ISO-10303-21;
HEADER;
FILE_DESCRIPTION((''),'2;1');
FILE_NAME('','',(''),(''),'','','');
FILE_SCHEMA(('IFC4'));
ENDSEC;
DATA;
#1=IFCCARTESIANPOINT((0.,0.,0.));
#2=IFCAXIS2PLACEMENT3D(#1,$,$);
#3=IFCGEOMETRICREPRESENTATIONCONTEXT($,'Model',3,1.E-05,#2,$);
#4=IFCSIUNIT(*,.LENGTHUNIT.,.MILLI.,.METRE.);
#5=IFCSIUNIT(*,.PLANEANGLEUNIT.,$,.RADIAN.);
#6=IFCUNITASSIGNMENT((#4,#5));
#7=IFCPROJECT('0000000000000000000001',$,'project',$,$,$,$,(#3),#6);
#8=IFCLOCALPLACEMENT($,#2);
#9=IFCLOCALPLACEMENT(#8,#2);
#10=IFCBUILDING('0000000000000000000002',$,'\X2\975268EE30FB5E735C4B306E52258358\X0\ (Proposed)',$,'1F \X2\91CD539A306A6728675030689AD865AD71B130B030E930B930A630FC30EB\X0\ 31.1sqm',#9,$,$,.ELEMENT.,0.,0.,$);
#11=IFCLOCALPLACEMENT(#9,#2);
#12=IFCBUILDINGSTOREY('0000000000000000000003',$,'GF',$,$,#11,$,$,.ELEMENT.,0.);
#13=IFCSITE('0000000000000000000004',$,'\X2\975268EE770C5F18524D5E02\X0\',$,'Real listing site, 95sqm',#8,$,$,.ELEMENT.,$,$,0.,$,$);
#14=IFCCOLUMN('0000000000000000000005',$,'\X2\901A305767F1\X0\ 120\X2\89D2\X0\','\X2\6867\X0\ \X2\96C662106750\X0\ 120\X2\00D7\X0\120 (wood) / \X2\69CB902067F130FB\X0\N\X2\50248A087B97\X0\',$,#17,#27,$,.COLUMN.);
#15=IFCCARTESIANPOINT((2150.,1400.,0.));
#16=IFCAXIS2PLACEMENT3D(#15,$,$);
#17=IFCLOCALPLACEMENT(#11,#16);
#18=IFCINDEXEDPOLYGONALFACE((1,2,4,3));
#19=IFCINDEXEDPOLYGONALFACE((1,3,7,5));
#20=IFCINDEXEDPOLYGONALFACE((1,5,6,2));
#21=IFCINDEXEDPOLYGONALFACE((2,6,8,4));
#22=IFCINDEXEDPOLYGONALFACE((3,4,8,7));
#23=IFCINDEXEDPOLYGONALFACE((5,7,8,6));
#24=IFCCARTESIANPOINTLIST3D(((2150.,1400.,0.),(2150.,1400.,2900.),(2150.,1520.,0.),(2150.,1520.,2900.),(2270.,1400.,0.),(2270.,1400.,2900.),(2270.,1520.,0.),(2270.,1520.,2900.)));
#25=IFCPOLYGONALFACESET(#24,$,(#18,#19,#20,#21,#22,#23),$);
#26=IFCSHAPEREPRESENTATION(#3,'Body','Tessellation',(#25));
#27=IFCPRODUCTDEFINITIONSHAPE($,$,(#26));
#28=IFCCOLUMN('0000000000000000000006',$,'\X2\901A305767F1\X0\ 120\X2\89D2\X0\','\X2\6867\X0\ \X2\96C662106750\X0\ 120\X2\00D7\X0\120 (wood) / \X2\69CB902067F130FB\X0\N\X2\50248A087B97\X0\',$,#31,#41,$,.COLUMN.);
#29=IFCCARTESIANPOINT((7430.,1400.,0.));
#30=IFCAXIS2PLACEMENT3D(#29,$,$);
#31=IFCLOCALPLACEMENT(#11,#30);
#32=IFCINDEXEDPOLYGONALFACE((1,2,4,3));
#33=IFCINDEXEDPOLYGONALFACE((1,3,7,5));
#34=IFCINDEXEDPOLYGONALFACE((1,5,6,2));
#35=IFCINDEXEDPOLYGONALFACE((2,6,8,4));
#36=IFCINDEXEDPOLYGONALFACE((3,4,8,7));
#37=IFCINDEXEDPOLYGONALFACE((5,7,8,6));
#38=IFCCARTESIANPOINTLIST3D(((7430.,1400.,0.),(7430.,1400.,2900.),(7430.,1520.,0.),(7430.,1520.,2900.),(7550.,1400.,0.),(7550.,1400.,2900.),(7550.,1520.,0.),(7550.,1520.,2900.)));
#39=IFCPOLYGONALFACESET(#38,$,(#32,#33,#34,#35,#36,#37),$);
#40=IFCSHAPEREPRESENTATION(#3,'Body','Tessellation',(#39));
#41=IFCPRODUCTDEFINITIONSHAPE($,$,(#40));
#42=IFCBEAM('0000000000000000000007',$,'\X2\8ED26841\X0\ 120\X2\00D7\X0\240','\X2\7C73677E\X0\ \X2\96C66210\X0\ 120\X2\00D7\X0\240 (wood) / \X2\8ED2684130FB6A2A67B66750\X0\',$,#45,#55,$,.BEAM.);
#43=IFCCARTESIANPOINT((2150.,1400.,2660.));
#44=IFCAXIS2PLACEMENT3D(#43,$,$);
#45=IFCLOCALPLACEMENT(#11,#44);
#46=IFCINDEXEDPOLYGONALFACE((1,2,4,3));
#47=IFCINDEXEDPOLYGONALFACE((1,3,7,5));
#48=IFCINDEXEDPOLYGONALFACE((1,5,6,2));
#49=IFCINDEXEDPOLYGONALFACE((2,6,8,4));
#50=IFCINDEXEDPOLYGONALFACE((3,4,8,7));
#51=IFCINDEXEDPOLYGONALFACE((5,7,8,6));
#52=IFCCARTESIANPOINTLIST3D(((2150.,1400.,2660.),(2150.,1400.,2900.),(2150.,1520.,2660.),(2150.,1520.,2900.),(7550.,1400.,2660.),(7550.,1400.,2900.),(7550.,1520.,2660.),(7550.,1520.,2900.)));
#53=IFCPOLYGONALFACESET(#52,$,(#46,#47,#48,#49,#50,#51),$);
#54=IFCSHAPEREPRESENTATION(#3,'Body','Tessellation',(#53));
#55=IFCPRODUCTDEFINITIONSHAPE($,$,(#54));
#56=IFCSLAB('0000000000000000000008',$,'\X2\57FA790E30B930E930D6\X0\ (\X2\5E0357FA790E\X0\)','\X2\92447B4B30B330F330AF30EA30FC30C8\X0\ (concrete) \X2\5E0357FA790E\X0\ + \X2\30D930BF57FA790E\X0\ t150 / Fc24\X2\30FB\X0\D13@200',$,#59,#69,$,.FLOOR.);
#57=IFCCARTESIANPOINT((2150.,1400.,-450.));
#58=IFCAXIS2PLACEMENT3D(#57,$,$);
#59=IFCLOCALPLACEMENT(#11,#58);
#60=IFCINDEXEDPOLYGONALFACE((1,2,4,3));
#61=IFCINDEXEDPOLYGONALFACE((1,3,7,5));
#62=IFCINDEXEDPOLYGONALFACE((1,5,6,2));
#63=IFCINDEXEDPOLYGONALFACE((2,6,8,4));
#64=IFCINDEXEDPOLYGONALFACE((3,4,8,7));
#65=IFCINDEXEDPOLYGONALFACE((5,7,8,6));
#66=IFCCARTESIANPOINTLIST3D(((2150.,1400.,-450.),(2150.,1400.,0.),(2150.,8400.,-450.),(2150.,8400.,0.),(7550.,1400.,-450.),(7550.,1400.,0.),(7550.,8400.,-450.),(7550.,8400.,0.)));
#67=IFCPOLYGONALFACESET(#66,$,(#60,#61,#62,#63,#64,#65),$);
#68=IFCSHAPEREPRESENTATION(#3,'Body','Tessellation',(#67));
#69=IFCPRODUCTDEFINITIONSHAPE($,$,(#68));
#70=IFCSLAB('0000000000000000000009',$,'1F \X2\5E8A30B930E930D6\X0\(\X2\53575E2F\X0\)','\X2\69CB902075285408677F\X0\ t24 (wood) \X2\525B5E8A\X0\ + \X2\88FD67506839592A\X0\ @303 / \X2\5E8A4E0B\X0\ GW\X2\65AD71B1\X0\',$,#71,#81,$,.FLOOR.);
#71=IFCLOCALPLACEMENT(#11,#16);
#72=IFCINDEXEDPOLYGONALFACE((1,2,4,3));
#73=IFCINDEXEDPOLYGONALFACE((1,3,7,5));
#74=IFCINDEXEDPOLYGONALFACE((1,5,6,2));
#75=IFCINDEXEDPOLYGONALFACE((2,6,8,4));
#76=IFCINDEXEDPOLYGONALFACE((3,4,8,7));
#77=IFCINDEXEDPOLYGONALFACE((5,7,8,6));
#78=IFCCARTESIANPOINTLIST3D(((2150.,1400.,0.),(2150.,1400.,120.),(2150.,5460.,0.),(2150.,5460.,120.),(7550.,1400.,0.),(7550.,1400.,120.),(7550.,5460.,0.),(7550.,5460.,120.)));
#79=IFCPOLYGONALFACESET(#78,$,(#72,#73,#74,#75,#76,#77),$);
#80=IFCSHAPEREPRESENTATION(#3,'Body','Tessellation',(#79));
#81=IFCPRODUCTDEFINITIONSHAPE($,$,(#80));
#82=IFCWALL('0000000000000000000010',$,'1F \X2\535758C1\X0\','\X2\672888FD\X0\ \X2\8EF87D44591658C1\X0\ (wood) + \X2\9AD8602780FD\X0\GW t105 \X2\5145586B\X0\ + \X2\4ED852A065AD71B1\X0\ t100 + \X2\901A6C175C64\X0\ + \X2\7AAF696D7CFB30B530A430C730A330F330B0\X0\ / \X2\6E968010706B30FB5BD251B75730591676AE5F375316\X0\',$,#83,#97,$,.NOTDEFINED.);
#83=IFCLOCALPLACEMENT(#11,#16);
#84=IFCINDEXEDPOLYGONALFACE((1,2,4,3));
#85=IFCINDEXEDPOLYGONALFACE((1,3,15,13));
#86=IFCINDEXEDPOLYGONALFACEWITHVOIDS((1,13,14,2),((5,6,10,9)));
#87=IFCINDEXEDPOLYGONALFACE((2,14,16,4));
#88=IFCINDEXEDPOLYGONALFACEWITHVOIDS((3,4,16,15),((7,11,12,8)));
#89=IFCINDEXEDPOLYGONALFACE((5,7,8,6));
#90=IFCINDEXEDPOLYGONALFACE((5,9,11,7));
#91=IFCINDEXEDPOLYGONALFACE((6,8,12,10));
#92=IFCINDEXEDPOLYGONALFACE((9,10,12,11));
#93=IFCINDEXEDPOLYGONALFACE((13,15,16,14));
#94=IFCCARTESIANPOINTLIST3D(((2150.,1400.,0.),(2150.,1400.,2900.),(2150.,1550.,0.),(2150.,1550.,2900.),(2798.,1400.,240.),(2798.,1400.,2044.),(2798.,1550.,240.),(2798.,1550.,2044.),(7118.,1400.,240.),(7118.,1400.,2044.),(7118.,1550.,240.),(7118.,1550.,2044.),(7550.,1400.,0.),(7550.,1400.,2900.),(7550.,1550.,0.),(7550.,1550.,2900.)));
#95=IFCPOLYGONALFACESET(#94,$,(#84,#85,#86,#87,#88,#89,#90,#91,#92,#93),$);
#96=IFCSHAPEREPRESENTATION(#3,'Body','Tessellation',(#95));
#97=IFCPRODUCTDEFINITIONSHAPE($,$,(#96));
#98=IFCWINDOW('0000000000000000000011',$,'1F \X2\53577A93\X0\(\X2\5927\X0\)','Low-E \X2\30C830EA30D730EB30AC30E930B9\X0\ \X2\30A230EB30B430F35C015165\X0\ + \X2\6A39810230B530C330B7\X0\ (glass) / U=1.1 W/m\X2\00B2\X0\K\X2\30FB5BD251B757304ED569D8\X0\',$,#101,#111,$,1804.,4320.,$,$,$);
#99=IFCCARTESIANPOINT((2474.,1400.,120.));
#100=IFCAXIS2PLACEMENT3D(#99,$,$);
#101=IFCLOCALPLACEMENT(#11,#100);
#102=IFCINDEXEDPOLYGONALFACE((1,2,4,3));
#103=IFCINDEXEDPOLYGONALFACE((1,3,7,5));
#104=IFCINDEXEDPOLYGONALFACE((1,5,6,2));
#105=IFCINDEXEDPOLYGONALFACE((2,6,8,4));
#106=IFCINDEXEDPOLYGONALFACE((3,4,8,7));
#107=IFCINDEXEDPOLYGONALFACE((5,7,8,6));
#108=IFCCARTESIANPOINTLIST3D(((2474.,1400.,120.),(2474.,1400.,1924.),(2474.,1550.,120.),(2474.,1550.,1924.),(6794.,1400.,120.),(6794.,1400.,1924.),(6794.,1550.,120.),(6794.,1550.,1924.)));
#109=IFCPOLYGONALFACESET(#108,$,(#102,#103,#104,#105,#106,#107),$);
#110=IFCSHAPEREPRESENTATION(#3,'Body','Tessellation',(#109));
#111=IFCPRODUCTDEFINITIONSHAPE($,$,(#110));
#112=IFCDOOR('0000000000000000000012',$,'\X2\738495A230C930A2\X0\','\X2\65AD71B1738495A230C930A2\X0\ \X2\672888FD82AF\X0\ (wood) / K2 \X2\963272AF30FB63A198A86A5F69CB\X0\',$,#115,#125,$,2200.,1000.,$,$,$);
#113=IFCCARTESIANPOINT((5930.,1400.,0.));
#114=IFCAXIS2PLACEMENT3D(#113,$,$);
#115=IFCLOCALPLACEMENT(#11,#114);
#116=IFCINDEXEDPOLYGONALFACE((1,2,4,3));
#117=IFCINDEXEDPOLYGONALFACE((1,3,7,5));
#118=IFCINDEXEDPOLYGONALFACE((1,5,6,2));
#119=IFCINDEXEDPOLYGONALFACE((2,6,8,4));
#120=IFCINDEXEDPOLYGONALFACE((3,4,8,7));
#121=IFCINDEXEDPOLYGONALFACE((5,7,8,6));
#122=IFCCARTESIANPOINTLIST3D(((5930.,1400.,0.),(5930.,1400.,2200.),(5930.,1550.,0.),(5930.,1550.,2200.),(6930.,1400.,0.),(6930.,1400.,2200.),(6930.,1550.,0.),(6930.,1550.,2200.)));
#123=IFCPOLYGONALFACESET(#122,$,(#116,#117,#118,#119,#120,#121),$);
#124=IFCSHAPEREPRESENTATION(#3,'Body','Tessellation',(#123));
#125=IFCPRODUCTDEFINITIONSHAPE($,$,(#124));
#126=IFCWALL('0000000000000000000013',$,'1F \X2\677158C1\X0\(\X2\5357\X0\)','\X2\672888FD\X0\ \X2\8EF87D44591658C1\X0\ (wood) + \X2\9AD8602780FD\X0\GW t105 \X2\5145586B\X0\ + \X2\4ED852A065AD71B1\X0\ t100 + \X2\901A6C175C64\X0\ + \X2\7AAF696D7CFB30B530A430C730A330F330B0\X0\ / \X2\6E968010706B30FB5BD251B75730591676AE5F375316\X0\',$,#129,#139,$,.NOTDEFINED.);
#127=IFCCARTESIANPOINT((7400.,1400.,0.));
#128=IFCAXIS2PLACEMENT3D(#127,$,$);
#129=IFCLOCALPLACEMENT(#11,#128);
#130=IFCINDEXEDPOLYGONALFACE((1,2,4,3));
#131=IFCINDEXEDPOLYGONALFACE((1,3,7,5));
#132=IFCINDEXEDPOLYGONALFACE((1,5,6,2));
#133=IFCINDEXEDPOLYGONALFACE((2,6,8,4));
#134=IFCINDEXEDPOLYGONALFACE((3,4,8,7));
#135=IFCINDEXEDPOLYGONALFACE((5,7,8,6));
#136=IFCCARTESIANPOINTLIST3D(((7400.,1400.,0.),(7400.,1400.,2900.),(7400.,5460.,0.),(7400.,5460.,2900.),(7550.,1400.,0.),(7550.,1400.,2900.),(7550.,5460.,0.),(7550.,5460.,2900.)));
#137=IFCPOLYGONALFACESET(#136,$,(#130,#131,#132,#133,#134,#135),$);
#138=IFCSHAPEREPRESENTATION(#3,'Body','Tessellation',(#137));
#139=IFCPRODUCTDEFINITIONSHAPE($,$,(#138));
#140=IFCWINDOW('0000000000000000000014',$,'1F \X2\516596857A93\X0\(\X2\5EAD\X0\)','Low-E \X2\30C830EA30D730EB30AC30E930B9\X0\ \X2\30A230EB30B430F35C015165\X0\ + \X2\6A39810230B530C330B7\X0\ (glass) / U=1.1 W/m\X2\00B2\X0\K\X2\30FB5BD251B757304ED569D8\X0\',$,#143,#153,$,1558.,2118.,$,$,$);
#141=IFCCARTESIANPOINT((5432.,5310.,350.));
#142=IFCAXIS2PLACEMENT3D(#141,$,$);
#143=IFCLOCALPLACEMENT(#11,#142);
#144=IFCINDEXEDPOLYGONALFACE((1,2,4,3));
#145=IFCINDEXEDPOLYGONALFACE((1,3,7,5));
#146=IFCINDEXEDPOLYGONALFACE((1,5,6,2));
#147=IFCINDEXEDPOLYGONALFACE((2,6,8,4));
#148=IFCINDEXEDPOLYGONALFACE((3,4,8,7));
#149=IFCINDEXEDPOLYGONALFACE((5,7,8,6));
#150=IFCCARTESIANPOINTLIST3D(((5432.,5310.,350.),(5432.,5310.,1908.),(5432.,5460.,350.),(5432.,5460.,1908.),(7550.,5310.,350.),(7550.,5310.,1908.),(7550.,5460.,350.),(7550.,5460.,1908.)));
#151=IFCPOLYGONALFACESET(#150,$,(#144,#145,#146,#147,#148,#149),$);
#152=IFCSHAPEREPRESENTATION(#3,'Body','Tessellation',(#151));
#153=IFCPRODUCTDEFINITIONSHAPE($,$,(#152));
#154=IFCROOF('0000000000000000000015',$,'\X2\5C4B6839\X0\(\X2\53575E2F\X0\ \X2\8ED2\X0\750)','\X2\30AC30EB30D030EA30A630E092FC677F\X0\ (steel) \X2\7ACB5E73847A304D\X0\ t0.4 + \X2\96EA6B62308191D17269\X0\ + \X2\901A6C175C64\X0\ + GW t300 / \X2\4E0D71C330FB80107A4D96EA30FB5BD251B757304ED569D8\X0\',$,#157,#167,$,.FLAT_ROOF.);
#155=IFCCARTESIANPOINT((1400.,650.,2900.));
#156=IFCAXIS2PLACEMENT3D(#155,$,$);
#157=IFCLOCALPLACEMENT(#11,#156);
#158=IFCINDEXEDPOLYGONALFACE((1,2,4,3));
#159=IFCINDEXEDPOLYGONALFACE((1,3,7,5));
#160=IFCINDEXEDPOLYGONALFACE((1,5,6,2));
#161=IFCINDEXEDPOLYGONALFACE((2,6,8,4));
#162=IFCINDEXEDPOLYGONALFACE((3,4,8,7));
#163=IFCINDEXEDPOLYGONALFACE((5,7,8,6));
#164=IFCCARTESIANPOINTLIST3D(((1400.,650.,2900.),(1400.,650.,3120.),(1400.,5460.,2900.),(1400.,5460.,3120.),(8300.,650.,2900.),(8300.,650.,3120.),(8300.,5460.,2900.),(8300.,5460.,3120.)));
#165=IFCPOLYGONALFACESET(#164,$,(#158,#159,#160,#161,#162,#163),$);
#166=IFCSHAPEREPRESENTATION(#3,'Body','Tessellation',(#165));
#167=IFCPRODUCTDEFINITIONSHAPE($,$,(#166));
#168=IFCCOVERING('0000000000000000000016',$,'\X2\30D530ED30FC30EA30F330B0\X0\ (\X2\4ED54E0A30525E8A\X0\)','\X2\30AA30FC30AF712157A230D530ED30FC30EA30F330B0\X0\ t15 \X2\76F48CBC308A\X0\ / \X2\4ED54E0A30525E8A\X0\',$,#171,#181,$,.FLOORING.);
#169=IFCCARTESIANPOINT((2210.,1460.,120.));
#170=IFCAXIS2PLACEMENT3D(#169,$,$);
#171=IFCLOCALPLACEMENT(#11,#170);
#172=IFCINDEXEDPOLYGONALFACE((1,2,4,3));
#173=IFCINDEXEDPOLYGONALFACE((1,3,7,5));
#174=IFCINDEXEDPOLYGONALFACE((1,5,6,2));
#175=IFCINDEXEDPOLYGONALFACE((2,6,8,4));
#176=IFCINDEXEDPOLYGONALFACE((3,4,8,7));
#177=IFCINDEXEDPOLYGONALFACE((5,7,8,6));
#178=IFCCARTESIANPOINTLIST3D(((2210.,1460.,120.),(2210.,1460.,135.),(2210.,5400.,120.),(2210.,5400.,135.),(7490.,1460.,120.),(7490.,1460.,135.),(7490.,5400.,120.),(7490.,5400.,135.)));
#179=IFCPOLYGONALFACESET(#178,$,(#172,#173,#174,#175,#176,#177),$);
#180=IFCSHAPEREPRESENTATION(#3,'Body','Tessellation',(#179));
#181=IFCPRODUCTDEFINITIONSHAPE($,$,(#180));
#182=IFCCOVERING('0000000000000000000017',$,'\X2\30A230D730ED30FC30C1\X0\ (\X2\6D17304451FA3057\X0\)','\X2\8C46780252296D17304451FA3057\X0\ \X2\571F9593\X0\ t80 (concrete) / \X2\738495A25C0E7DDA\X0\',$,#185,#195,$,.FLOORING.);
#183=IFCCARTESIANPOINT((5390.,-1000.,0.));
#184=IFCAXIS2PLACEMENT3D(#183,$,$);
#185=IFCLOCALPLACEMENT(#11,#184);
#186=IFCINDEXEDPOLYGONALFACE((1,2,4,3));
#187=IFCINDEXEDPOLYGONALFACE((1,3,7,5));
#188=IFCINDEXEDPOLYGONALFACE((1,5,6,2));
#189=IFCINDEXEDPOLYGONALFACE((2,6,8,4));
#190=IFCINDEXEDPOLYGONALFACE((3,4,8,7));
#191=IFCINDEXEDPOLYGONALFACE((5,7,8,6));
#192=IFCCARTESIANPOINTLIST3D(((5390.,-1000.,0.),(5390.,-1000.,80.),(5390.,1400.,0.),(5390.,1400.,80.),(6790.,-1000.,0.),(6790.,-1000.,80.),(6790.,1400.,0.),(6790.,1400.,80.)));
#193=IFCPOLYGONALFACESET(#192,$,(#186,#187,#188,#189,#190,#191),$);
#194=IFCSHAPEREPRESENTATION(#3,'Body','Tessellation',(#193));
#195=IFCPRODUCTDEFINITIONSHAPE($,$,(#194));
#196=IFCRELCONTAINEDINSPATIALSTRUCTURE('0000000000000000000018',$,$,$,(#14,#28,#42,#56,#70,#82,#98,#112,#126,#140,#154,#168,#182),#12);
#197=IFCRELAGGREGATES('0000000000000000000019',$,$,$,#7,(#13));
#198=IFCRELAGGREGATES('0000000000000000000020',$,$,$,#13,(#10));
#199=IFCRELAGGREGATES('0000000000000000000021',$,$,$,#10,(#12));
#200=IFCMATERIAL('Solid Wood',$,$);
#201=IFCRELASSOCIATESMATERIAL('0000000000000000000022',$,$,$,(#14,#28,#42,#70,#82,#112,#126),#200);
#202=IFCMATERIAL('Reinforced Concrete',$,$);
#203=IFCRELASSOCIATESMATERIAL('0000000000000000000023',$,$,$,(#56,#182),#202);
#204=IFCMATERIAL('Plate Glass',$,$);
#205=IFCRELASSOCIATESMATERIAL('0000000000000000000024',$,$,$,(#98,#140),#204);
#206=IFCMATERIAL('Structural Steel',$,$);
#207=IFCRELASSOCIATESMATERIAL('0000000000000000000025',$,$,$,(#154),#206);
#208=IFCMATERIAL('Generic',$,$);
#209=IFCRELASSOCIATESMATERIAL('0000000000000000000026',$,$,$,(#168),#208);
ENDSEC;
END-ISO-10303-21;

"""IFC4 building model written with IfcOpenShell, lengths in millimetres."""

from ifc_helpers import new_model, si_unit, frame, frame_2d, origin, place, context, project, spatial, rectangle, extrude, material, element, fill, save


model = new_model("IFC4")

# Units and contexts
model_context = context("Model", 3, precision=1e-05, world=origin())
ifc_project = project(units=[si_unit("LENGTHUNIT", "METRE", prefix="MILLI"), si_unit("PLANEANGLEUNIT", "RADIAN")], contexts=[model_context])

# Site, building, storey
site_placement = place(None, origin())
site = spatial("IfcSite", under=ifc_project, at=site_placement, Name="青森県弘前市", ObjectType="Real listing site, 95sqm", CompositionType="ELEMENT", RefElevation=0.0)
building_placement = place(site_placement, origin())
building = spatial("IfcBuilding", under=site, at=building_placement, Name="青森・平屋の別荘 (Proposed)", ObjectType="1F 重厚な木材と高断熱グラスウール 31.1sqm", CompositionType="ELEMENT", ElevationOfRefHeight=0.0, ElevationOfTerrain=0.0)
storey_placement = place(building_placement, origin())
storey = spatial("IfcBuildingStorey", under=building, at=storey_placement, Name="GF", CompositionType="ELEMENT", Elevation=0.0)

# Columns
ifc_material_1 = material(Name="Solid Wood")
column_1_placement = place(storey_placement, frame((2150.0, 1400.0, 0.0)))
element("IfcColumn", 1, at=column_1_placement, inside=storey, material=ifc_material_1, Name="通し柱 120角", Description="桧 集成材 120×120 (wood) / 構造柱・N値計算", PredefinedType="COLUMN", context=model_context, shape_type="SweptSolid", body=[
    extrude(rectangle(XDim=120.0, YDim=120.0, at=frame_2d((60.0, 60.0))), frame((2150.0, 1400.0, 0.0)), (0.0, 0.0, 1.0), 2900.0),
])
column_2_placement = place(storey_placement, frame((7430.0, 1400.0, 0.0)))
element("IfcColumn", 2, at=column_2_placement, inside=storey, material=ifc_material_1, Name="通し柱 120角", Description="桧 集成材 120×120 (wood) / 構造柱・N値計算", PredefinedType="COLUMN", context=model_context, shape_type="SweptSolid", body=[
    extrude(rectangle(XDim=120.0, YDim=120.0, at=frame_2d((60.0, 60.0))), frame((7430.0, 1400.0, 0.0)), (0.0, 0.0, 1.0), 2900.0),
])

# Beam
beam_1_placement = place(storey_placement, frame((2150.0, 1400.0, 2660.0)))
element("IfcBeam", 3, at=beam_1_placement, inside=storey, material=ifc_material_1, Name="軒桁 120×240", Description="米松 集成 120×240 (wood) / 軒桁・横架材", PredefinedType="BEAM", context=model_context, shape_type="SweptSolid", body=[
    extrude(rectangle(XDim=5400.0, YDim=120.0, at=frame_2d((2700.0, 60.0))), frame((2150.0, 1400.0, 2660.0)), (0.0, 0.0, 1.0), 240.0),
])

# Slabs
ifc_material_2 = material(Name="Reinforced Concrete")
slab_1_placement = place(storey_placement, frame((2150.0, 1400.0, -450.0)))
element("IfcSlab", 4, at=slab_1_placement, inside=storey, material=ifc_material_2, Name="基礎スラブ (布基礎)", Description="鉄筋コンクリート (concrete) 布基礎 + ベタ基礎 t150 / Fc24・D13@200", PredefinedType="FLOOR", context=model_context, shape_type="SweptSolid", body=[
    extrude(rectangle(XDim=5400.0, YDim=7000.0, at=frame_2d((2700.0, 3500.0))), frame((2150.0, 1400.0, -450.0)), (0.0, 0.0, 1.0), 450.0),
])
slab_2_placement = place(storey_placement, frame((2150.0, 1400.0, 0.0)))
element("IfcSlab", 5, at=slab_2_placement, inside=storey, material=ifc_material_1, Name="1F 床スラブ(南帯)", Description="構造用合板 t24 (wood) 剛床 + 製材根太 @303 / 床下 GW断熱", PredefinedType="FLOOR", context=model_context, shape_type="SweptSolid", body=[
    extrude(rectangle(XDim=5400.0, YDim=4060.0, at=frame_2d((2700.0, 2030.0))), frame((2150.0, 1400.0, 0.0)), (0.0, 0.0, 1.0), 120.0),
])

# Wall, openings, window, door
wall_1_placement = place(storey_placement, frame((2150.0, 1400.0, 0.0)))
wall_1 = element("IfcWall", 6, at=wall_1_placement, inside=storey, material=ifc_material_1, Name="1F 南壁", Description="木製 軸組外壁 (wood) + 高性能GW t105 充填 + 付加断熱 t100 + 通気層 + 窯業系サイディング / 準耐火・寒冷地外皮強化", PredefinedType="NOTDEFINED", context=model_context, shape_type="SweptSolid", body=[
    extrude(rectangle(XDim=5400.0, YDim=150.0, at=frame_2d((2700.0, 75.0))), frame((2150.0, 1400.0, 0.0)), (0.0, 0.0, 1.0), 2900.0),
])
opening_1_placement = place(storey_placement, frame((2474.0, 1400.0, 120.0)))
opening_1 = element("IfcOpeningElement", 7, at=opening_1_placement, cuts=wall_1, PredefinedType="NOTDEFINED", context=model_context, shape_type="SweptSolid", body=[
    extrude(rectangle(XDim=4320.0, YDim=150.0, at=frame_2d((2160.0, 75.0))), frame((2474.0, 1400.0, 120.0)), (0.0, 0.0, 1.0), 1804.0),
])
opening_2_placement = place(storey_placement, frame((5930.0, 1400.0, 0.0)))
opening_2 = element("IfcOpeningElement", 8, at=opening_2_placement, cuts=wall_1, PredefinedType="NOTDEFINED", context=model_context, shape_type="SweptSolid", body=[
    extrude(rectangle(XDim=1000.0, YDim=150.0, at=frame_2d((500.0, 75.0))), frame((5930.0, 1400.0, 0.0)), (0.0, 0.0, 1.0), 2200.0),
])
ifc_material_3 = material(Name="Plate Glass")
window_1_placement = place(storey_placement, frame((2474.0, 1400.0, 120.0)))
window_1 = element("IfcWindow", 9, at=window_1_placement, inside=storey, material=ifc_material_3, Name="1F 南窓(大)", Description="Low-E トリプルガラス アルゴン封入 + 樹脂サッシ (glass) / U=1.1 W/m²K・寒冷地仕様", OverallHeight=1804.0, OverallWidth=4320.0, context=model_context, shape_type="SweptSolid", body=[
    extrude(rectangle(XDim=4320.0, YDim=150.0, at=frame_2d((2160.0, 75.0))), frame((2474.0, 1400.0, 120.0)), (0.0, 0.0, 1.0), 1804.0),
])
fill(opening_1, window_1)
door_1_placement = place(storey_placement, frame((5930.0, 1400.0, 0.0)))
door_1 = element("IfcDoor", 10, at=door_1_placement, inside=storey, material=ifc_material_1, Name="玄関ドア", Description="断熱玄関ドア 木製芯 (wood) / K2 防犯・採風機構", OverallHeight=2200.0, OverallWidth=1000.0, context=model_context, shape_type="SweptSolid", body=[
    extrude(rectangle(XDim=1000.0, YDim=150.0, at=frame_2d((500.0, 75.0))), frame((5930.0, 1400.0, 0.0)), (0.0, 0.0, 1.0), 2200.0),
])
fill(opening_2, door_1)

# Wall, opening, window
wall_2_placement = place(storey_placement, frame((7400.0, 1400.0, 0.0)))
wall_2 = element("IfcWall", 11, at=wall_2_placement, inside=storey, material=ifc_material_1, Name="1F 東壁(南)", Description="木製 軸組外壁 (wood) + 高性能GW t105 充填 + 付加断熱 t100 + 通気層 + 窯業系サイディング / 準耐火・寒冷地外皮強化", PredefinedType="NOTDEFINED", context=model_context, shape_type="SweptSolid", body=[
    extrude(rectangle(XDim=150.0, YDim=4060.0, at=frame_2d((75.0, 2030.0))), frame((7400.0, 1400.0, 0.0)), (0.0, 0.0, 1.0), 2900.0),
])
opening_3_placement = place(storey_placement, frame((5432.0, 5310.0, 350.0)))
opening_3 = element("IfcOpeningElement", 12, at=opening_3_placement, cuts=wall_2, PredefinedType="NOTDEFINED", context=model_context, shape_type="SweptSolid", body=[
    extrude(rectangle(XDim=2118.0, YDim=150.0, at=frame_2d((1059.0, 75.0))), frame((5432.0, 5310.0, 350.0)), (0.0, 0.0, 1.0), 1558.0),
])
window_2_placement = place(storey_placement, frame((5432.0, 5310.0, 350.0)))
window_2 = element("IfcWindow", 13, at=window_2_placement, inside=storey, material=ifc_material_3, Name="1F 入隅窓(庭)", Description="Low-E トリプルガラス アルゴン封入 + 樹脂サッシ (glass) / U=1.1 W/m²K・寒冷地仕様", OverallHeight=1558.0, OverallWidth=2118.0, context=model_context, shape_type="SweptSolid", body=[
    extrude(rectangle(XDim=2118.0, YDim=150.0, at=frame_2d((1059.0, 75.0))), frame((5432.0, 5310.0, 350.0)), (0.0, 0.0, 1.0), 1558.0),
])
fill(opening_3, window_2)

# Roof
ifc_material_4 = material(Name="Structural Steel")
roof_placement = place(storey_placement, frame((1400.0, 650.0, 2900.0)))
element("IfcRoof", 14, at=roof_placement, inside=storey, material=ifc_material_4, Name="屋根(南帯 軒750)", Description="ガルバリウム鋼板 (steel) 立平葺き t0.4 + 雪止め金物 + 通気層 + GW t300 / 不燃・耐積雪・寒冷地仕様", PredefinedType="FLAT_ROOF", context=model_context, shape_type="SweptSolid", body=[
    extrude(rectangle(XDim=6900.0, YDim=4810.0, at=frame_2d((3450.0, 2405.0))), frame((1400.0, 650.0, 2900.0)), (0.0, 0.0, 1.0), 220.0),
])

# Coverings
ifc_material_5 = material(Name="Generic")
covering_1_placement = place(storey_placement, frame((2210.0, 1460.0, 120.0)))
element("IfcCovering", 15, at=covering_1_placement, inside=storey, material=ifc_material_5, Name="フローリング (仕上げ床)", Description="オーク無垢フローリング t15 直貼り / 仕上げ床", PredefinedType="FLOORING", context=model_context, shape_type="SweptSolid", body=[
    extrude(rectangle(XDim=5280.0, YDim=3940.0, at=frame_2d((2640.0, 1970.0))), frame((2210.0, 1460.0, 120.0)), (0.0, 0.0, 1.0), 15.0),
])
covering_2_placement = place(storey_placement, frame((5390.0, -1000.0, 0.0)))
element("IfcCovering", 16, at=covering_2_placement, inside=storey, material=ifc_material_2, Name="アプローチ (洗い出し)", Description="豆砂利洗い出し 土間 t80 (concrete) / 玄関導線", PredefinedType="FLOORING", context=model_context, shape_type="SweptSolid", body=[
    extrude(rectangle(XDim=1400.0, YDim=2400.0, at=frame_2d((700.0, 1200.0))), frame((5390.0, -1000.0, 0.0)), (0.0, 0.0, 1.0), 80.0),
])

save(model, "model.ifc")
